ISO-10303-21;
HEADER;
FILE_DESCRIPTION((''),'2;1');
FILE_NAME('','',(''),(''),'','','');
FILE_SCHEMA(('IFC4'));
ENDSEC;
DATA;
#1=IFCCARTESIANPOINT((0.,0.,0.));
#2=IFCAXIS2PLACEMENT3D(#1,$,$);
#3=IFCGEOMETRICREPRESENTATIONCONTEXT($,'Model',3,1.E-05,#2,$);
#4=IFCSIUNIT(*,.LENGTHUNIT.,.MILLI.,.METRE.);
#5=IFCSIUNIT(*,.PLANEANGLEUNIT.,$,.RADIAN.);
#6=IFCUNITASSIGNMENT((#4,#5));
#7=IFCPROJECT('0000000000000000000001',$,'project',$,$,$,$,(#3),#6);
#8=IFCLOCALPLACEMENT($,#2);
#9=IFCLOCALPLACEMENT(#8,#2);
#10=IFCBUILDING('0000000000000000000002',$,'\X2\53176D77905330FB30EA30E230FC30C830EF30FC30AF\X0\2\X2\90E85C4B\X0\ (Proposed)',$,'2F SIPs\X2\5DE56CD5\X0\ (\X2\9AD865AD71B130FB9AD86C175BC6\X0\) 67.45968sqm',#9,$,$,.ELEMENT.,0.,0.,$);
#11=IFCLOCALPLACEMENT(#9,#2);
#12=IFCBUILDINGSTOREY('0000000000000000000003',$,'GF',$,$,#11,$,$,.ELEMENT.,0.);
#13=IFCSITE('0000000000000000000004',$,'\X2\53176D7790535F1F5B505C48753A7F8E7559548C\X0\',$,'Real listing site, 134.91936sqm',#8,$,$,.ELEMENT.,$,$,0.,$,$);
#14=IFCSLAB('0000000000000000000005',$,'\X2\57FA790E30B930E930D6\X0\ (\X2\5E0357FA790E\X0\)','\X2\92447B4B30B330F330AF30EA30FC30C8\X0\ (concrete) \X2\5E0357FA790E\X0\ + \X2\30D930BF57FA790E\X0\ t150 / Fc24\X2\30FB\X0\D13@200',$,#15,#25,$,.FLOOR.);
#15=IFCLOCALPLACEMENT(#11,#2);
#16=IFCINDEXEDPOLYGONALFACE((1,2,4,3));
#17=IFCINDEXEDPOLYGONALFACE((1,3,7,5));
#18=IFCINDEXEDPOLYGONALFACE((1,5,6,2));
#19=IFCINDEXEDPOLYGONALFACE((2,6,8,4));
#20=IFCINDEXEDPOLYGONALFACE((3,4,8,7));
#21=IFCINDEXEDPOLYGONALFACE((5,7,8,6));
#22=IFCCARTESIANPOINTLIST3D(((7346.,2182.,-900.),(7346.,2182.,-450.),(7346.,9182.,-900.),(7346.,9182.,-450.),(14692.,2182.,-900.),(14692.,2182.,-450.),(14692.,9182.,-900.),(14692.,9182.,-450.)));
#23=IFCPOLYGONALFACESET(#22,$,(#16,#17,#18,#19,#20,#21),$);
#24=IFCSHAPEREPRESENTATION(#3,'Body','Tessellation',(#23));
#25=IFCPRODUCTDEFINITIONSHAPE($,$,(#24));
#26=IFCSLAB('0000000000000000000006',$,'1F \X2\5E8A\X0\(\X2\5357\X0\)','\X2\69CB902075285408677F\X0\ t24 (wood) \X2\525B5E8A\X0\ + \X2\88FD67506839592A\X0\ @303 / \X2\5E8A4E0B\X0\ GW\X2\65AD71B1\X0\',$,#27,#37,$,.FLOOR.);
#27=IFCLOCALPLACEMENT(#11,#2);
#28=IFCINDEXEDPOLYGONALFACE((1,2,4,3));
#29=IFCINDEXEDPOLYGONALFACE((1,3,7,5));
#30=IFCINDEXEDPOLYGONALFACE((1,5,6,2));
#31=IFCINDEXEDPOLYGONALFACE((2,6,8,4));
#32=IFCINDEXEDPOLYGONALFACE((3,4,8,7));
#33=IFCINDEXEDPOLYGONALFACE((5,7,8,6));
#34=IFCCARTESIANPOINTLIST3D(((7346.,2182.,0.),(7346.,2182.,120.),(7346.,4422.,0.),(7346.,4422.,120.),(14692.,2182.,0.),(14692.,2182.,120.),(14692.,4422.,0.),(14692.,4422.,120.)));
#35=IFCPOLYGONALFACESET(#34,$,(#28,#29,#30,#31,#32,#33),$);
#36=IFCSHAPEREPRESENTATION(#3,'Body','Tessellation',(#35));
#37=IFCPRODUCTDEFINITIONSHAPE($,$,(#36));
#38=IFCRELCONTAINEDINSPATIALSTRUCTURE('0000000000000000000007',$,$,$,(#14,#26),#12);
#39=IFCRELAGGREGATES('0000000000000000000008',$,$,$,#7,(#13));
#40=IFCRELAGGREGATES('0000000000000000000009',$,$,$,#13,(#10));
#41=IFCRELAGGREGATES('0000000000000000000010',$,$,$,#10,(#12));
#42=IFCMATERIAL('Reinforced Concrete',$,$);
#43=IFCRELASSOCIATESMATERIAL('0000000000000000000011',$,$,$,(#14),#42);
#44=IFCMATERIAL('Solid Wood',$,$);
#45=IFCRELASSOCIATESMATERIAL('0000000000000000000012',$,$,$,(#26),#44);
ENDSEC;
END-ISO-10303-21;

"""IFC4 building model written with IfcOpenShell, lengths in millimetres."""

from ifc_helpers import new_model, si_unit, frame, frame_2d, origin, place, context, project, spatial, rectangle, extrude, material, element, save


model = new_model("IFC4")

# Units and contexts
model_context = context("Model", 3, precision=1e-05, world=origin())
ifc_project = project(units=[si_unit("LENGTHUNIT", "METRE", prefix="MILLI"), si_unit("PLANEANGLEUNIT", "RADIAN")], contexts=[model_context])

# Site, building, storey
site_placement = place(None, origin())
site = spatial("IfcSite", under=ifc_project, at=site_placement, Name="北海道弟子屈町美留和", ObjectType="Real listing site, 134.91936sqm", CompositionType="ELEMENT", RefElevation=0.0)
building_placement = place(site_placement, origin())
building = spatial("IfcBuilding", under=site, at=building_placement, Name="北海道・リモートワーク2部屋 (Proposed)", ObjectType="2F SIPs工法 (高断熱・高気密) 67.45968sqm", CompositionType="ELEMENT", ElevationOfRefHeight=0.0, ElevationOfTerrain=0.0)
storey_placement = place(building_placement, origin())
storey = spatial("IfcBuildingStorey", under=building, at=storey_placement, Name="GF", CompositionType="ELEMENT", Elevation=0.0)

# Slabs
ifc_material_1 = material(Name="Reinforced Concrete")
slab_1_placement = place(storey_placement, frame((3673.0, 1091.0, -450.0)))
element("IfcSlab", 1, at=slab_1_placement, inside=storey, material=ifc_material_1, Name="基礎スラブ (布基礎)", Description="鉄筋コンクリート (concrete) 布基礎 + ベタ基礎 t150 / Fc24・D13@200", PredefinedType="FLOOR", context=model_context, shape_type="SweptSolid", body=[
    extrude(rectangle(XDim=7346.0, YDim=7000.0, at=frame_2d((3673.0, 3500.0))), frame((3673.0, 1091.0, -450.0)), (0.0, 0.0, 1.0), 450.0),
])
ifc_material_2 = material(Name="Solid Wood")
slab_2_placement = place(storey_placement, frame((3673.0, 1091.0, 0.0)))
element("IfcSlab", 2, at=slab_2_placement, inside=storey, material=ifc_material_2, Name="1F 床(南)", Description="構造用合板 t24 (wood) 剛床 + 製材根太 @303 / 床下 GW断熱", PredefinedType="FLOOR", context=model_context, shape_type="SweptSolid", body=[
    extrude(rectangle(XDim=7346.0, YDim=2240.0, at=frame_2d((3673.0, 1120.0))), frame((3673.0, 1091.0, 0.0)), (0.0, 0.0, 1.0), 120.0),
])

save(model, "model.ifc")
